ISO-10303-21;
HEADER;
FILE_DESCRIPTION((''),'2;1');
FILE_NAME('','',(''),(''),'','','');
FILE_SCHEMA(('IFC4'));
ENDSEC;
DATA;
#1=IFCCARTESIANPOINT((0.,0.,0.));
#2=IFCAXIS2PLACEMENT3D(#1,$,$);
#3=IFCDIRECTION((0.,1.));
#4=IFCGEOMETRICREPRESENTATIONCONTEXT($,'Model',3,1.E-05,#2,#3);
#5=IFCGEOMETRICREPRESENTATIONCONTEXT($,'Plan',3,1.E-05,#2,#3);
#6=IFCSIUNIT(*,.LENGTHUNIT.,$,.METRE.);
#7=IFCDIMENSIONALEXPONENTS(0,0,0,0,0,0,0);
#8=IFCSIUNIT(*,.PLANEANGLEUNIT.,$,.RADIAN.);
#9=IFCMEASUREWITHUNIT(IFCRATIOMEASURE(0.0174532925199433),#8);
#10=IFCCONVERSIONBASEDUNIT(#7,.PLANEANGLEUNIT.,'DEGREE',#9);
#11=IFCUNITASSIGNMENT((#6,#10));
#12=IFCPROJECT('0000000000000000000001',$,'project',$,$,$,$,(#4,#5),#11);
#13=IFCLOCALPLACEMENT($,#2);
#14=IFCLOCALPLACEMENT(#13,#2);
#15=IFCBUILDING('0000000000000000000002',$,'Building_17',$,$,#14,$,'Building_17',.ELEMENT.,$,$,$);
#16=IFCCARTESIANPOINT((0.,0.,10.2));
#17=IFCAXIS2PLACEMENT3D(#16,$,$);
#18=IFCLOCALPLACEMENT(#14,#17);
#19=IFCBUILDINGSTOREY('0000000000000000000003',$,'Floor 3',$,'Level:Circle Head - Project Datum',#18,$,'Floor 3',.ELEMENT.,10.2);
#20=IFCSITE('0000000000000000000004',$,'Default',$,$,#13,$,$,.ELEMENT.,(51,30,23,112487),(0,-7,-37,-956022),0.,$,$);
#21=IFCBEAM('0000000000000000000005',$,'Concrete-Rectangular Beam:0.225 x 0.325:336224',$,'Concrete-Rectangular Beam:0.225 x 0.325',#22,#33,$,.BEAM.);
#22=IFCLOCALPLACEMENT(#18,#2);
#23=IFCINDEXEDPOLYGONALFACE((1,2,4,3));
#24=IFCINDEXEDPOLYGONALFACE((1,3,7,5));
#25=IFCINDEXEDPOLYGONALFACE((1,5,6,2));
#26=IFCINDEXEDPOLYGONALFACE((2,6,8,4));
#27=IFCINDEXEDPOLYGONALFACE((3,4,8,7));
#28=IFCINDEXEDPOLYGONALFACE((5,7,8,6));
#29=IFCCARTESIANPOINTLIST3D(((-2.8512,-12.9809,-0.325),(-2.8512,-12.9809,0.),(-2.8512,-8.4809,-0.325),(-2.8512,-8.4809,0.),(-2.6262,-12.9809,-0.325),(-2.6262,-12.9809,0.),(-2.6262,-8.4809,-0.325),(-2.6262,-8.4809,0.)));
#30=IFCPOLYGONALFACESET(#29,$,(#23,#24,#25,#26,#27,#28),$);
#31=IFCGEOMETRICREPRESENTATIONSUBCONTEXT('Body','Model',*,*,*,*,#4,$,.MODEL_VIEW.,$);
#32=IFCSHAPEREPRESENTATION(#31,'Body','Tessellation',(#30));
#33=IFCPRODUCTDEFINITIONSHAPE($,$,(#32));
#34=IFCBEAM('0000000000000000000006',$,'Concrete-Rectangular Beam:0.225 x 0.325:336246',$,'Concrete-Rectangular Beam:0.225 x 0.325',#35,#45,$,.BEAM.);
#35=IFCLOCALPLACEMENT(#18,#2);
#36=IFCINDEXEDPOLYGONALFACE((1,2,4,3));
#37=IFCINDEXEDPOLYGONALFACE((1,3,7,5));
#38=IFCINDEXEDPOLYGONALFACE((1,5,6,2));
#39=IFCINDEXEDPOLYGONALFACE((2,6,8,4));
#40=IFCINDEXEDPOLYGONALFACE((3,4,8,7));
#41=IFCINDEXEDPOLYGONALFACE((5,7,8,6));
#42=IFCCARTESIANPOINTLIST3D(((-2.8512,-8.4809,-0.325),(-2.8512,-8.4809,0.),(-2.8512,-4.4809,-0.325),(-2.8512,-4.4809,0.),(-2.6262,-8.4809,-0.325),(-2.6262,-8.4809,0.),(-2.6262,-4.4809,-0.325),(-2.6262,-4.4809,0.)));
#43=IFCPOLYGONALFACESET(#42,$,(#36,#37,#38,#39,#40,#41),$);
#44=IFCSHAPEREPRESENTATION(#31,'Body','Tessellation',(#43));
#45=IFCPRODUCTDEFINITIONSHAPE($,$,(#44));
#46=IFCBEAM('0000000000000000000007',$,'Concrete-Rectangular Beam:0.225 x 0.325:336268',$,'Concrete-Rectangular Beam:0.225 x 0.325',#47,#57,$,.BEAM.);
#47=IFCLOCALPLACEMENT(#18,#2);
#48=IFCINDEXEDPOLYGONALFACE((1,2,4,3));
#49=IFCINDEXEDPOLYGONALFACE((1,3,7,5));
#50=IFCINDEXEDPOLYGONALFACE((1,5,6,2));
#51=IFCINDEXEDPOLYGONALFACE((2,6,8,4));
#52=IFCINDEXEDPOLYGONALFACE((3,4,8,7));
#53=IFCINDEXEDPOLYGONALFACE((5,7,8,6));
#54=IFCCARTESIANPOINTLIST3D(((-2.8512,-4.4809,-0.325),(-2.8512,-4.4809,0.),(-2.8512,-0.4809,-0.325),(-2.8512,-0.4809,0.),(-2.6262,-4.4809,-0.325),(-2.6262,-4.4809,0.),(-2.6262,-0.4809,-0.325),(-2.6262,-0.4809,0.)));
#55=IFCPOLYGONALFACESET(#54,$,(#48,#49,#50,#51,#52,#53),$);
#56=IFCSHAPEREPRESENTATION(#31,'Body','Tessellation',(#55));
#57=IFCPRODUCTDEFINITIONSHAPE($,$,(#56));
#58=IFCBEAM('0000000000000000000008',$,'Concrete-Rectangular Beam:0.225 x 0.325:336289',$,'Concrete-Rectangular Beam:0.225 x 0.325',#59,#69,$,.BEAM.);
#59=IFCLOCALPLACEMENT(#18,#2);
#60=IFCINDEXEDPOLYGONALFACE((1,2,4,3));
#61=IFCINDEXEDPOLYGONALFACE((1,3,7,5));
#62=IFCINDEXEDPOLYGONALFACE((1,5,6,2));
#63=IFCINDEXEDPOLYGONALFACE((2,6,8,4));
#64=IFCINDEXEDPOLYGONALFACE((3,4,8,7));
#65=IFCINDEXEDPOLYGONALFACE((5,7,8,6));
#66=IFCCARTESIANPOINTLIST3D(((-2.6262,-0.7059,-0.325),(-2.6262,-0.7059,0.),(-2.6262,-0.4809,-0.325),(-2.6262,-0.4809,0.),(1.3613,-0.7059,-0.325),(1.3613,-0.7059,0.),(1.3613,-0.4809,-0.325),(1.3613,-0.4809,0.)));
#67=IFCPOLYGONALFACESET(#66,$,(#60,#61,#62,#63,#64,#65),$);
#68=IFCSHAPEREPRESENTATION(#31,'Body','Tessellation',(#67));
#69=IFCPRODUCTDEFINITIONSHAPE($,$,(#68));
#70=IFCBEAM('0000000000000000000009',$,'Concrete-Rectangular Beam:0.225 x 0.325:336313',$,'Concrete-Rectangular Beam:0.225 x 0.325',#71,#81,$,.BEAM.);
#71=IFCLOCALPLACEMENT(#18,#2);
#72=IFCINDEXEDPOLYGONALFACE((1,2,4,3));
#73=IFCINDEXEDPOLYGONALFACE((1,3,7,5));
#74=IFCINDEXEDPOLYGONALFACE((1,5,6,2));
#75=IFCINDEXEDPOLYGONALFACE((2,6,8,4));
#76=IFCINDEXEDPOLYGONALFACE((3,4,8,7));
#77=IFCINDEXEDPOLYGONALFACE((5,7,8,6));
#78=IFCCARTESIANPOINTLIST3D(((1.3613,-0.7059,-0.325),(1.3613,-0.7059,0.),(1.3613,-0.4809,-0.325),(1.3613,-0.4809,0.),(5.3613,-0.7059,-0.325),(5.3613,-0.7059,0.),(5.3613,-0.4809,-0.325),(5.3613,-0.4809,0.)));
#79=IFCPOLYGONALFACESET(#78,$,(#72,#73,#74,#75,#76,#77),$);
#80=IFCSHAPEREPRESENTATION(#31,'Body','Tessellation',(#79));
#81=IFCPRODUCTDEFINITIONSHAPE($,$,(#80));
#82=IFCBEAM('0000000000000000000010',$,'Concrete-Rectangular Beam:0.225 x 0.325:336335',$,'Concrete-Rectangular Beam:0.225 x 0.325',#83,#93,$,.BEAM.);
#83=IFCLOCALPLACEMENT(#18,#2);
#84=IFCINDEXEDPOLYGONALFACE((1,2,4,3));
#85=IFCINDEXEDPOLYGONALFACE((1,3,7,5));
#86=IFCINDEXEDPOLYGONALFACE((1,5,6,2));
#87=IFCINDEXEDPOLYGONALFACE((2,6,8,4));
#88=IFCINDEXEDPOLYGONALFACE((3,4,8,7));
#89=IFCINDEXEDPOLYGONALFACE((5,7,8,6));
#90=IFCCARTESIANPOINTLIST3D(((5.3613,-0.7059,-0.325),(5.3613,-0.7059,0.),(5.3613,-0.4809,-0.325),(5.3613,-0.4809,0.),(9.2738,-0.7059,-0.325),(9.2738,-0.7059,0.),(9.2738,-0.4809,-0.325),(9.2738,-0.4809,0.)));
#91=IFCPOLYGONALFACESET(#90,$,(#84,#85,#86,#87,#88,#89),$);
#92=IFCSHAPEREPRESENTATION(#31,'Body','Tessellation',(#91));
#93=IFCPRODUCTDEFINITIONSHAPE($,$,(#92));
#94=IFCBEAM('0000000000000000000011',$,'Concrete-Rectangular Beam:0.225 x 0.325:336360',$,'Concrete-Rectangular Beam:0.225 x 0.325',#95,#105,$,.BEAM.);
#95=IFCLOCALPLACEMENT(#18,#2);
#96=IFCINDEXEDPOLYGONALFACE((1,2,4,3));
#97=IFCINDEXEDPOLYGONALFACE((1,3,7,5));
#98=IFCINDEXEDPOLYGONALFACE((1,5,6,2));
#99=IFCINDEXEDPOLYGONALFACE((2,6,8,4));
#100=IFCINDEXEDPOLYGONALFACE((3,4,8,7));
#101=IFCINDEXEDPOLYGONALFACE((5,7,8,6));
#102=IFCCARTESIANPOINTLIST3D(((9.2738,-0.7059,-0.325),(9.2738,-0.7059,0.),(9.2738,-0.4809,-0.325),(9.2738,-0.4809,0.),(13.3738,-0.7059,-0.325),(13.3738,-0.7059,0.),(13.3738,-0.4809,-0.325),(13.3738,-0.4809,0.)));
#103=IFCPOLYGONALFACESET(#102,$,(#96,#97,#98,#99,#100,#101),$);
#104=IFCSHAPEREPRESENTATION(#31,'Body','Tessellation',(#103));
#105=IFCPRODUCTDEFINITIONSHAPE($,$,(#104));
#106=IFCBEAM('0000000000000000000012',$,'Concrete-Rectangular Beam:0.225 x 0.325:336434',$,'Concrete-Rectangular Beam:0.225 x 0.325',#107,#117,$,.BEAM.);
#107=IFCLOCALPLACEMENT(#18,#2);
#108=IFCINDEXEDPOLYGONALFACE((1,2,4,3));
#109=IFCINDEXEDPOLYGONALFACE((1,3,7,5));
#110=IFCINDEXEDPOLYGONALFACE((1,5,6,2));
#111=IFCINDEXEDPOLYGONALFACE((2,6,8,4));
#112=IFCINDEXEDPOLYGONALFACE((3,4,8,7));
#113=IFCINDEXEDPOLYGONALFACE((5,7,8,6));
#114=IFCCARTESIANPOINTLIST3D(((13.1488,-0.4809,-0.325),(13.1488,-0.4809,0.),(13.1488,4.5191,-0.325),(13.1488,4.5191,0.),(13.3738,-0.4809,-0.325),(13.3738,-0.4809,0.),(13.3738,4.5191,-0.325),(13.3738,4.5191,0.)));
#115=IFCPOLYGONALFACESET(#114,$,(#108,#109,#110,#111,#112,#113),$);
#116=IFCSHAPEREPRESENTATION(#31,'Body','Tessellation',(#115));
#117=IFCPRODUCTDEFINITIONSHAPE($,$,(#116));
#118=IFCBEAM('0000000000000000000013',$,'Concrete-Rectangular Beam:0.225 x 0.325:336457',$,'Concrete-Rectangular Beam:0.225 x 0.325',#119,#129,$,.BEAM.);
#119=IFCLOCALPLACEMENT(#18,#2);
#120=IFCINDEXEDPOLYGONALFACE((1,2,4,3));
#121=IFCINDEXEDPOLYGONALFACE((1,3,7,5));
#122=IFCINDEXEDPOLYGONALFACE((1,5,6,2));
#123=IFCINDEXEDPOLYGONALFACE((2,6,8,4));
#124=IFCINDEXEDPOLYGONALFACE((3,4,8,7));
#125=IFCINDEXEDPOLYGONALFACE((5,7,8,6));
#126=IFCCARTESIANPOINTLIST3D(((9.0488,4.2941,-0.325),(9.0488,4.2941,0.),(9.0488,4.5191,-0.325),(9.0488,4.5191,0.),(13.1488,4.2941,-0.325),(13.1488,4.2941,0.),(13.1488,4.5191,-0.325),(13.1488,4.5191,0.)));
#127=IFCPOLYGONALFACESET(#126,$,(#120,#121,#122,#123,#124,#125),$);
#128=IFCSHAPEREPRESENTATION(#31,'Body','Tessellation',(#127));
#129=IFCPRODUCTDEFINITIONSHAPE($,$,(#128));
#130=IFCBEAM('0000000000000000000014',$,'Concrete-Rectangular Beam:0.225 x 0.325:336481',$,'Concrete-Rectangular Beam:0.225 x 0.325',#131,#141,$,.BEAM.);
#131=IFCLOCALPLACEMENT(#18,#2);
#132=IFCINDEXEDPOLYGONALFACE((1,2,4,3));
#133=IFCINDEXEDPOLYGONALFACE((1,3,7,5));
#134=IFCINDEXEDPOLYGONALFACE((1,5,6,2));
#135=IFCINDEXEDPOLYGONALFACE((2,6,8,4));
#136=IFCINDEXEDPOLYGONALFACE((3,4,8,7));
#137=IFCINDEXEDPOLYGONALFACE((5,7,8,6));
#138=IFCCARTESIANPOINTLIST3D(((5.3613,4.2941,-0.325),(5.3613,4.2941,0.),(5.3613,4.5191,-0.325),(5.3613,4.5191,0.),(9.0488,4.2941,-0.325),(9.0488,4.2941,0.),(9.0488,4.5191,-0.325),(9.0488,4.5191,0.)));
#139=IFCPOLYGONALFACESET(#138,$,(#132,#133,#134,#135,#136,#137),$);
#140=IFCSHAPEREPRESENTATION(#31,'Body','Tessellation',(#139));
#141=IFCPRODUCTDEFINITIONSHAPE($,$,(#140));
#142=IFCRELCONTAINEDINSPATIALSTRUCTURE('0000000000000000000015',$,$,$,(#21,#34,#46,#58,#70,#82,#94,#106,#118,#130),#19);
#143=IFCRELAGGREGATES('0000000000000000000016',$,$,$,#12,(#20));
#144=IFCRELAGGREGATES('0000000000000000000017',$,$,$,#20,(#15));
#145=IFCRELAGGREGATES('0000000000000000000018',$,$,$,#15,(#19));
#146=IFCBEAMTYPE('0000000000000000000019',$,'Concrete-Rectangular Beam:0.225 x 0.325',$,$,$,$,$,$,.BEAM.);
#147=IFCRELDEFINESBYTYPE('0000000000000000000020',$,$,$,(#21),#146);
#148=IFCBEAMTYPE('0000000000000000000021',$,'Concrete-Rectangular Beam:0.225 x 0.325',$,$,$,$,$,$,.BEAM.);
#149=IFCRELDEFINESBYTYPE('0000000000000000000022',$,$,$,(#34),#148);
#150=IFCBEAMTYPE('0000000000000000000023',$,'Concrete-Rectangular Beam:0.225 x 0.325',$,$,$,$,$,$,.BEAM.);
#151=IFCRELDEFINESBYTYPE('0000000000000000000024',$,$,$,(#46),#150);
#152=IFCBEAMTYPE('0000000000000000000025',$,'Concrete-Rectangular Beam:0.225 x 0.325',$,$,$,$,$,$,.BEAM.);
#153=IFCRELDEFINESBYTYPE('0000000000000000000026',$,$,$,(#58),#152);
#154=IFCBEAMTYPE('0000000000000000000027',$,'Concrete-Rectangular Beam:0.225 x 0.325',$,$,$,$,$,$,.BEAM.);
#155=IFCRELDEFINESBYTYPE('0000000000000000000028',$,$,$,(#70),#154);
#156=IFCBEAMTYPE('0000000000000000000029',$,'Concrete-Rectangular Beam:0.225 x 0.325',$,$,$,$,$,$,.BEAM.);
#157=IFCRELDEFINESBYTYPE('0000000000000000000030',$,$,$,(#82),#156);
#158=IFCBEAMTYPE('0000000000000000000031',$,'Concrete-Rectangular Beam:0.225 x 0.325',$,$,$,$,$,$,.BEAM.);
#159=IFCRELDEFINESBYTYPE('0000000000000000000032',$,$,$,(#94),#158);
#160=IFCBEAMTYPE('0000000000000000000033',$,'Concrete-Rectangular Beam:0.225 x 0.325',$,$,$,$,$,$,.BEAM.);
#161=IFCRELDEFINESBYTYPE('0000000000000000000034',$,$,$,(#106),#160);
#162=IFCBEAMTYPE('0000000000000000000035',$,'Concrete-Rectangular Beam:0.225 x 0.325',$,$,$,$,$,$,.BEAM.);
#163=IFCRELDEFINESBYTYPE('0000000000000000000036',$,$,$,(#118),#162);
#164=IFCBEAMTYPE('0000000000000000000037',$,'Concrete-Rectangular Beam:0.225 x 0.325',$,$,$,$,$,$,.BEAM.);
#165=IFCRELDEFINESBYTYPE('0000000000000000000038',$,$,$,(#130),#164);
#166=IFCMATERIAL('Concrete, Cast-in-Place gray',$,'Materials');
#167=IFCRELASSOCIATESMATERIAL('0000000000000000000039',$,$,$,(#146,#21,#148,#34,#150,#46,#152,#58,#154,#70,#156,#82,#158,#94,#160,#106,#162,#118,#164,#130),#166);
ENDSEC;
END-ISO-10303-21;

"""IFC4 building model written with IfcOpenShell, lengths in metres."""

from ifc_helpers import new_model, entity, si_unit, converted_unit, direction, frame, origin, place, context, subcontext, project, spatial, indexed_curve, outline, extrude, source, transform, mapped, material, type_object, type_shapes, element, save


model = new_model("IFC4")

# Units and contexts
model_context = context("Model", 3, precision=1e-05, world=origin(), true_north=direction((0.0, 1.0)))
plan_context = context("Plan", 3, precision=1e-05, world=origin(), true_north=direction((0.0, 1.0)))
body_context = subcontext(model_context, "Body", "Model", "MODEL_VIEW")
ifc_project = project(units=[si_unit("LENGTHUNIT", "METRE"), converted_unit("PLANEANGLEUNIT", "DEGREE", entity("IfcRatioMeasure", 0.0174532925199433), si_unit("PLANEANGLEUNIT", "RADIAN"), dimensions=[0, 0, 0, 0, 0, 0, 0])], contexts=[model_context, plan_context])

# Site, building, storey
site_placement = place(None, origin())
site = spatial("IfcSite", under=ifc_project, at=site_placement, Name="Default", CompositionType="ELEMENT", RefLatitude=(51, 30, 23, 112487), RefLongitude=(0, -7, -37, -956022), RefElevation=0.0)
building_placement = place(site_placement, origin())
building = spatial("IfcBuilding", under=site, at=building_placement, Name="Building_17", LongName="Building_17", CompositionType="ELEMENT")
storey_placement = place(building_placement, frame((0.0, 0.0, 10.2)))
storey = spatial("IfcBuildingStorey", under=building, at=storey_placement, Name="Floor 3", ObjectType="Level:Circle Head - Project Datum", LongName="Floor 3", CompositionType="ELEMENT", Elevation=10.2)

# Beams
ifc_material_1 = material(Name="Concrete, Cast-in-Place gray", Category="Materials")
beam_type_1 = type_object("IfcBeamType", Name="Concrete-Rectangular Beam:0.225 x 0.325", PredefinedType="BEAM", material=ifc_material_1)
shared_shape_1 = source(origin(), body_context, "Body", "SweptSolid", [
    extrude(outline(indexed_curve([(-0.1125, -0.1625), (0.1125, -0.1625), (0.1125, 0.1625), (-0.1125, 0.1625), (-0.1125, -0.1625)], self_intersect=False)), frame((-2.7387, -12.9809, 10.0375), z_axis=(0.0, 1.0, 0.0), x_axis=(-1.0, 0.0, 0.0)), (0.0, 0.0, 1.0), 4.5),
])
type_shapes(beam_type_1, [shared_shape_1])
beam_1_placement = place(storey_placement, frame((0.0, 0.0, -10.2)))
element("IfcBeam", 1, at=beam_1_placement, inside=storey, type_object=beam_type_1, material=ifc_material_1, Name="Concrete-Rectangular Beam:0.225 x 0.325:336224", ObjectType="Concrete-Rectangular Beam:0.225 x 0.325", PredefinedType="BEAM", context=body_context, shape_type="MappedRepresentation", body=[
    mapped(shared_shape_1, transform((0.0, 0.0, 0.0), scale=1.0)),
])
beam_type_2 = type_object("IfcBeamType", Name="Concrete-Rectangular Beam:0.225 x 0.325", PredefinedType="BEAM", material=ifc_material_1)
shared_shape_2 = source(origin(), body_context, "Body", "SweptSolid", [
    extrude(outline(indexed_curve([(-0.1125, -0.1625), (0.1125, -0.1625), (0.1125, 0.1625), (-0.1125, 0.1625), (-0.1125, -0.1625)], self_intersect=False)), frame((-2.7387, -8.4809, 10.0375), z_axis=(0.0, 1.0, 0.0), x_axis=(-1.0, 0.0, 0.0)), (0.0, 0.0, 1.0), 4.0),
])
type_shapes(beam_type_2, [shared_shape_2])
beam_2_placement = place(storey_placement, frame((0.0, 0.0, -10.2)))
element("IfcBeam", 2, at=beam_2_placement, inside=storey, type_object=beam_type_2, material=ifc_material_1, Name="Concrete-Rectangular Beam:0.225 x 0.325:336246", ObjectType="Concrete-Rectangular Beam:0.225 x 0.325", PredefinedType="BEAM", context=body_context, shape_type="MappedRepresentation", body=[
    mapped(shared_shape_2, transform((0.0, 0.0, 0.0), scale=1.0)),
])
beam_type_3 = type_object("IfcBeamType", Name="Concrete-Rectangular Beam:0.225 x 0.325", PredefinedType="BEAM", material=ifc_material_1)
shared_shape_3 = source(origin(), body_context, "Body", "SweptSolid", [
    extrude(outline(indexed_curve([(-0.1125, -0.1625), (0.1125, -0.1625), (0.1125, 0.1625), (-0.1125, 0.1625), (-0.1125, -0.1625)], self_intersect=False)), frame((-2.7387, -4.4809, 10.0375), z_axis=(0.0, 1.0, 0.0), x_axis=(-1.0, 0.0, 0.0)), (0.0, 0.0, 1.0), 4.0),
])
type_shapes(beam_type_3, [shared_shape_3])
beam_3_placement = place(storey_placement, frame((0.0, 0.0, -10.2)))
element("IfcBeam", 3, at=beam_3_placement, inside=storey, type_object=beam_type_3, material=ifc_material_1, Name="Concrete-Rectangular Beam:0.225 x 0.325:336268", ObjectType="Concrete-Rectangular Beam:0.225 x 0.325", PredefinedType="BEAM", context=body_context, shape_type="MappedRepresentation", body=[
    mapped(shared_shape_3, transform((0.0, 0.0, 0.0), scale=1.0)),
])
beam_type_4 = type_object("IfcBeamType", Name="Concrete-Rectangular Beam:0.225 x 0.325", PredefinedType="BEAM", material=ifc_material_1)
shared_shape_4 = source(origin(), body_context, "Body", "SweptSolid", [
    extrude(outline(indexed_curve([(-0.1625, -0.1125), (0.1625, -0.1125), (0.1625, 0.1125), (-0.1625, 0.1125), (-0.1625, -0.1125)], self_intersect=False)), frame((-2.6262, -0.5934, 10.0375), z_axis=(1.0, 0.0, 0.0), x_axis=(0.0, 0.0, -1.0)), (0.0, 0.0, 1.0), 3.9875),
])
type_shapes(beam_type_4, [shared_shape_4])
beam_4_placement = place(storey_placement, frame((0.0, 0.0, -10.2)))
element("IfcBeam", 4, at=beam_4_placement, inside=storey, type_object=beam_type_4, material=ifc_material_1, Name="Concrete-Rectangular Beam:0.225 x 0.325:336289", ObjectType="Concrete-Rectangular Beam:0.225 x 0.325", PredefinedType="BEAM", context=body_context, shape_type="MappedRepresentation", body=[
    mapped(shared_shape_4, transform((0.0, 0.0, 0.0), scale=1.0)),
])
beam_type_5 = type_object("IfcBeamType", Name="Concrete-Rectangular Beam:0.225 x 0.325", PredefinedType="BEAM", material=ifc_material_1)
shared_shape_5 = source(origin(), body_context, "Body", "SweptSolid", [
    extrude(outline(indexed_curve([(-0.1625, -0.1125), (0.1625, -0.1125), (0.1625, 0.1125), (-0.1625, 0.1125), (-0.1625, -0.1125)], self_intersect=False)), frame((1.3613, -0.5934, 10.0375), z_axis=(1.0, 0.0, 0.0), x_axis=(0.0, 0.0, -1.0)), (0.0, 0.0, 1.0), 4.0),
])
type_shapes(beam_type_5, [shared_shape_5])
beam_5_placement = place(storey_placement, frame((0.0, 0.0, -10.2)))
element("IfcBeam", 5, at=beam_5_placement, inside=storey, type_object=beam_type_5, material=ifc_material_1, Name="Concrete-Rectangular Beam:0.225 x 0.325:336313", ObjectType="Concrete-Rectangular Beam:0.225 x 0.325", PredefinedType="BEAM", context=body_context, shape_type="MappedRepresentation", body=[
    mapped(shared_shape_5, transform((0.0, 0.0, 0.0), scale=1.0)),
])
beam_type_6 = type_object("IfcBeamType", Name="Concrete-Rectangular Beam:0.225 x 0.325", PredefinedType="BEAM", material=ifc_material_1)
shared_shape_6 = source(origin(), body_context, "Body", "SweptSolid", [
    extrude(outline(indexed_curve([(-0.1625, -0.1125), (0.1625, -0.1125), (0.1625, 0.1125), (-0.1625, 0.1125), (-0.1625, -0.1125)], self_intersect=False)), frame((5.3613, -0.5934, 10.0375), z_axis=(1.0, 0.0, 0.0), x_axis=(0.0, 0.0, -1.0)), (0.0, 0.0, 1.0), 3.9125),
])
type_shapes(beam_type_6, [shared_shape_6])
beam_6_placement = place(storey_placement, frame((0.0, 0.0, -10.2)))
element("IfcBeam", 6, at=beam_6_placement, inside=storey, type_object=beam_type_6, material=ifc_material_1, Name="Concrete-Rectangular Beam:0.225 x 0.325:336335", ObjectType="Concrete-Rectangular Beam:0.225 x 0.325", PredefinedType="BEAM", context=body_context, shape_type="MappedRepresentation", body=[
    mapped(shared_shape_6, transform((0.0, 0.0, 0.0), scale=1.0)),
])
beam_type_7 = type_object("IfcBeamType", Name="Concrete-Rectangular Beam:0.225 x 0.325", PredefinedType="BEAM", material=ifc_material_1)
shared_shape_7 = source(origin(), body_context, "Body", "SweptSolid", [
    extrude(outline(indexed_curve([(-0.1625, -0.1125), (0.1625, -0.1125), (0.1625, 0.1125), (-0.1625, 0.1125), (-0.1625, -0.1125)], self_intersect=False)), frame((9.2738, -0.5934, 10.0375), z_axis=(1.0, 0.0, 0.0), x_axis=(0.0, 0.0, -1.0)), (0.0, 0.0, 1.0), 4.1),
])
type_shapes(beam_type_7, [shared_shape_7])
beam_7_placement = place(storey_placement, frame((0.0, 0.0, -10.2)))
element("IfcBeam", 7, at=beam_7_placement, inside=storey, type_object=beam_type_7, material=ifc_material_1, Name="Concrete-Rectangular Beam:0.225 x 0.325:336360", ObjectType="Concrete-Rectangular Beam:0.225 x 0.325", PredefinedType="BEAM", context=body_context, shape_type="MappedRepresentation", body=[
    mapped(shared_shape_7, transform((0.0, 0.0, 0.0), scale=1.0)),
])
beam_type_8 = type_object("IfcBeamType", Name="Concrete-Rectangular Beam:0.225 x 0.325", PredefinedType="BEAM", material=ifc_material_1)
shared_shape_8 = source(origin(), body_context, "Body", "SweptSolid", [
    extrude(outline(indexed_curve([(-0.1125, -0.1625), (0.1125, -0.1625), (0.1125, 0.1625), (-0.1125, 0.1625), (-0.1125, -0.1625)], self_intersect=False)), frame((13.2613, -0.4809, 10.0375), z_axis=(0.0, 1.0, 0.0), x_axis=(-1.0, 0.0, 0.0)), (0.0, 0.0, 1.0), 5.0),
])
type_shapes(beam_type_8, [shared_shape_8])
beam_8_placement = place(storey_placement, frame((0.0, 0.0, -10.2)))
element("IfcBeam", 8, at=beam_8_placement, inside=storey, type_object=beam_type_8, material=ifc_material_1, Name="Concrete-Rectangular Beam:0.225 x 0.325:336434", ObjectType="Concrete-Rectangular Beam:0.225 x 0.325", PredefinedType="BEAM", context=body_context, shape_type="MappedRepresentation", body=[
    mapped(shared_shape_8, transform((0.0, 0.0, 0.0), scale=1.0)),
])
beam_type_9 = type_object("IfcBeamType", Name="Concrete-Rectangular Beam:0.225 x 0.325", PredefinedType="BEAM", material=ifc_material_1)
shared_shape_9 = source(origin(), body_context, "Body", "SweptSolid", [
    extrude(outline(indexed_curve([(-0.1625, -0.1125), (0.1625, -0.1125), (0.1625, 0.1125), (-0.1625, 0.1125), (-0.1625, -0.1125)], self_intersect=False)), frame((13.1488, 4.4066, 10.0375), z_axis=(-1.0, 0.0, 0.0), x_axis=(0.0, 0.0, -1.0)), (0.0, 0.0, 1.0), 4.1),
])
type_shapes(beam_type_9, [shared_shape_9])
beam_9_placement = place(storey_placement, frame((0.0, 0.0, -10.2)))
element("IfcBeam", 9, at=beam_9_placement, inside=storey, type_object=beam_type_9, material=ifc_material_1, Name="Concrete-Rectangular Beam:0.225 x 0.325:336457", ObjectType="Concrete-Rectangular Beam:0.225 x 0.325", PredefinedType="BEAM", context=body_context, shape_type="MappedRepresentation", body=[
    mapped(shared_shape_9, transform((0.0, 0.0, 0.0), scale=1.0)),
])
beam_type_10 = type_object("IfcBeamType", Name="Concrete-Rectangular Beam:0.225 x 0.325", PredefinedType="BEAM", material=ifc_material_1)
shared_shape_10 = source(origin(), body_context, "Body", "SweptSolid", [
    extrude(outline(indexed_curve([(-0.1625, -0.1125), (0.1625, -0.1125), (0.1625, 0.1125), (-0.1625, 0.1125), (-0.1625, -0.1125)], self_intersect=False)), frame((9.0488, 4.4066, 10.0375), z_axis=(-1.0, 0.0, 0.0), x_axis=(0.0, 0.0, -1.0)), (0.0, 0.0, 1.0), 3.6875),
])
type_shapes(beam_type_10, [shared_shape_10])
beam_10_placement = place(storey_placement, frame((0.0, 0.0, -10.2)))
element("IfcBeam", 10, at=beam_10_placement, inside=storey, type_object=beam_type_10, material=ifc_material_1, Name="Concrete-Rectangular Beam:0.225 x 0.325:336481", ObjectType="Concrete-Rectangular Beam:0.225 x 0.325", PredefinedType="BEAM", context=body_context, shape_type="MappedRepresentation", body=[
    mapped(shared_shape_10, transform((0.0, 0.0, 0.0), scale=1.0)),
])

save(model, "model.ifc")
